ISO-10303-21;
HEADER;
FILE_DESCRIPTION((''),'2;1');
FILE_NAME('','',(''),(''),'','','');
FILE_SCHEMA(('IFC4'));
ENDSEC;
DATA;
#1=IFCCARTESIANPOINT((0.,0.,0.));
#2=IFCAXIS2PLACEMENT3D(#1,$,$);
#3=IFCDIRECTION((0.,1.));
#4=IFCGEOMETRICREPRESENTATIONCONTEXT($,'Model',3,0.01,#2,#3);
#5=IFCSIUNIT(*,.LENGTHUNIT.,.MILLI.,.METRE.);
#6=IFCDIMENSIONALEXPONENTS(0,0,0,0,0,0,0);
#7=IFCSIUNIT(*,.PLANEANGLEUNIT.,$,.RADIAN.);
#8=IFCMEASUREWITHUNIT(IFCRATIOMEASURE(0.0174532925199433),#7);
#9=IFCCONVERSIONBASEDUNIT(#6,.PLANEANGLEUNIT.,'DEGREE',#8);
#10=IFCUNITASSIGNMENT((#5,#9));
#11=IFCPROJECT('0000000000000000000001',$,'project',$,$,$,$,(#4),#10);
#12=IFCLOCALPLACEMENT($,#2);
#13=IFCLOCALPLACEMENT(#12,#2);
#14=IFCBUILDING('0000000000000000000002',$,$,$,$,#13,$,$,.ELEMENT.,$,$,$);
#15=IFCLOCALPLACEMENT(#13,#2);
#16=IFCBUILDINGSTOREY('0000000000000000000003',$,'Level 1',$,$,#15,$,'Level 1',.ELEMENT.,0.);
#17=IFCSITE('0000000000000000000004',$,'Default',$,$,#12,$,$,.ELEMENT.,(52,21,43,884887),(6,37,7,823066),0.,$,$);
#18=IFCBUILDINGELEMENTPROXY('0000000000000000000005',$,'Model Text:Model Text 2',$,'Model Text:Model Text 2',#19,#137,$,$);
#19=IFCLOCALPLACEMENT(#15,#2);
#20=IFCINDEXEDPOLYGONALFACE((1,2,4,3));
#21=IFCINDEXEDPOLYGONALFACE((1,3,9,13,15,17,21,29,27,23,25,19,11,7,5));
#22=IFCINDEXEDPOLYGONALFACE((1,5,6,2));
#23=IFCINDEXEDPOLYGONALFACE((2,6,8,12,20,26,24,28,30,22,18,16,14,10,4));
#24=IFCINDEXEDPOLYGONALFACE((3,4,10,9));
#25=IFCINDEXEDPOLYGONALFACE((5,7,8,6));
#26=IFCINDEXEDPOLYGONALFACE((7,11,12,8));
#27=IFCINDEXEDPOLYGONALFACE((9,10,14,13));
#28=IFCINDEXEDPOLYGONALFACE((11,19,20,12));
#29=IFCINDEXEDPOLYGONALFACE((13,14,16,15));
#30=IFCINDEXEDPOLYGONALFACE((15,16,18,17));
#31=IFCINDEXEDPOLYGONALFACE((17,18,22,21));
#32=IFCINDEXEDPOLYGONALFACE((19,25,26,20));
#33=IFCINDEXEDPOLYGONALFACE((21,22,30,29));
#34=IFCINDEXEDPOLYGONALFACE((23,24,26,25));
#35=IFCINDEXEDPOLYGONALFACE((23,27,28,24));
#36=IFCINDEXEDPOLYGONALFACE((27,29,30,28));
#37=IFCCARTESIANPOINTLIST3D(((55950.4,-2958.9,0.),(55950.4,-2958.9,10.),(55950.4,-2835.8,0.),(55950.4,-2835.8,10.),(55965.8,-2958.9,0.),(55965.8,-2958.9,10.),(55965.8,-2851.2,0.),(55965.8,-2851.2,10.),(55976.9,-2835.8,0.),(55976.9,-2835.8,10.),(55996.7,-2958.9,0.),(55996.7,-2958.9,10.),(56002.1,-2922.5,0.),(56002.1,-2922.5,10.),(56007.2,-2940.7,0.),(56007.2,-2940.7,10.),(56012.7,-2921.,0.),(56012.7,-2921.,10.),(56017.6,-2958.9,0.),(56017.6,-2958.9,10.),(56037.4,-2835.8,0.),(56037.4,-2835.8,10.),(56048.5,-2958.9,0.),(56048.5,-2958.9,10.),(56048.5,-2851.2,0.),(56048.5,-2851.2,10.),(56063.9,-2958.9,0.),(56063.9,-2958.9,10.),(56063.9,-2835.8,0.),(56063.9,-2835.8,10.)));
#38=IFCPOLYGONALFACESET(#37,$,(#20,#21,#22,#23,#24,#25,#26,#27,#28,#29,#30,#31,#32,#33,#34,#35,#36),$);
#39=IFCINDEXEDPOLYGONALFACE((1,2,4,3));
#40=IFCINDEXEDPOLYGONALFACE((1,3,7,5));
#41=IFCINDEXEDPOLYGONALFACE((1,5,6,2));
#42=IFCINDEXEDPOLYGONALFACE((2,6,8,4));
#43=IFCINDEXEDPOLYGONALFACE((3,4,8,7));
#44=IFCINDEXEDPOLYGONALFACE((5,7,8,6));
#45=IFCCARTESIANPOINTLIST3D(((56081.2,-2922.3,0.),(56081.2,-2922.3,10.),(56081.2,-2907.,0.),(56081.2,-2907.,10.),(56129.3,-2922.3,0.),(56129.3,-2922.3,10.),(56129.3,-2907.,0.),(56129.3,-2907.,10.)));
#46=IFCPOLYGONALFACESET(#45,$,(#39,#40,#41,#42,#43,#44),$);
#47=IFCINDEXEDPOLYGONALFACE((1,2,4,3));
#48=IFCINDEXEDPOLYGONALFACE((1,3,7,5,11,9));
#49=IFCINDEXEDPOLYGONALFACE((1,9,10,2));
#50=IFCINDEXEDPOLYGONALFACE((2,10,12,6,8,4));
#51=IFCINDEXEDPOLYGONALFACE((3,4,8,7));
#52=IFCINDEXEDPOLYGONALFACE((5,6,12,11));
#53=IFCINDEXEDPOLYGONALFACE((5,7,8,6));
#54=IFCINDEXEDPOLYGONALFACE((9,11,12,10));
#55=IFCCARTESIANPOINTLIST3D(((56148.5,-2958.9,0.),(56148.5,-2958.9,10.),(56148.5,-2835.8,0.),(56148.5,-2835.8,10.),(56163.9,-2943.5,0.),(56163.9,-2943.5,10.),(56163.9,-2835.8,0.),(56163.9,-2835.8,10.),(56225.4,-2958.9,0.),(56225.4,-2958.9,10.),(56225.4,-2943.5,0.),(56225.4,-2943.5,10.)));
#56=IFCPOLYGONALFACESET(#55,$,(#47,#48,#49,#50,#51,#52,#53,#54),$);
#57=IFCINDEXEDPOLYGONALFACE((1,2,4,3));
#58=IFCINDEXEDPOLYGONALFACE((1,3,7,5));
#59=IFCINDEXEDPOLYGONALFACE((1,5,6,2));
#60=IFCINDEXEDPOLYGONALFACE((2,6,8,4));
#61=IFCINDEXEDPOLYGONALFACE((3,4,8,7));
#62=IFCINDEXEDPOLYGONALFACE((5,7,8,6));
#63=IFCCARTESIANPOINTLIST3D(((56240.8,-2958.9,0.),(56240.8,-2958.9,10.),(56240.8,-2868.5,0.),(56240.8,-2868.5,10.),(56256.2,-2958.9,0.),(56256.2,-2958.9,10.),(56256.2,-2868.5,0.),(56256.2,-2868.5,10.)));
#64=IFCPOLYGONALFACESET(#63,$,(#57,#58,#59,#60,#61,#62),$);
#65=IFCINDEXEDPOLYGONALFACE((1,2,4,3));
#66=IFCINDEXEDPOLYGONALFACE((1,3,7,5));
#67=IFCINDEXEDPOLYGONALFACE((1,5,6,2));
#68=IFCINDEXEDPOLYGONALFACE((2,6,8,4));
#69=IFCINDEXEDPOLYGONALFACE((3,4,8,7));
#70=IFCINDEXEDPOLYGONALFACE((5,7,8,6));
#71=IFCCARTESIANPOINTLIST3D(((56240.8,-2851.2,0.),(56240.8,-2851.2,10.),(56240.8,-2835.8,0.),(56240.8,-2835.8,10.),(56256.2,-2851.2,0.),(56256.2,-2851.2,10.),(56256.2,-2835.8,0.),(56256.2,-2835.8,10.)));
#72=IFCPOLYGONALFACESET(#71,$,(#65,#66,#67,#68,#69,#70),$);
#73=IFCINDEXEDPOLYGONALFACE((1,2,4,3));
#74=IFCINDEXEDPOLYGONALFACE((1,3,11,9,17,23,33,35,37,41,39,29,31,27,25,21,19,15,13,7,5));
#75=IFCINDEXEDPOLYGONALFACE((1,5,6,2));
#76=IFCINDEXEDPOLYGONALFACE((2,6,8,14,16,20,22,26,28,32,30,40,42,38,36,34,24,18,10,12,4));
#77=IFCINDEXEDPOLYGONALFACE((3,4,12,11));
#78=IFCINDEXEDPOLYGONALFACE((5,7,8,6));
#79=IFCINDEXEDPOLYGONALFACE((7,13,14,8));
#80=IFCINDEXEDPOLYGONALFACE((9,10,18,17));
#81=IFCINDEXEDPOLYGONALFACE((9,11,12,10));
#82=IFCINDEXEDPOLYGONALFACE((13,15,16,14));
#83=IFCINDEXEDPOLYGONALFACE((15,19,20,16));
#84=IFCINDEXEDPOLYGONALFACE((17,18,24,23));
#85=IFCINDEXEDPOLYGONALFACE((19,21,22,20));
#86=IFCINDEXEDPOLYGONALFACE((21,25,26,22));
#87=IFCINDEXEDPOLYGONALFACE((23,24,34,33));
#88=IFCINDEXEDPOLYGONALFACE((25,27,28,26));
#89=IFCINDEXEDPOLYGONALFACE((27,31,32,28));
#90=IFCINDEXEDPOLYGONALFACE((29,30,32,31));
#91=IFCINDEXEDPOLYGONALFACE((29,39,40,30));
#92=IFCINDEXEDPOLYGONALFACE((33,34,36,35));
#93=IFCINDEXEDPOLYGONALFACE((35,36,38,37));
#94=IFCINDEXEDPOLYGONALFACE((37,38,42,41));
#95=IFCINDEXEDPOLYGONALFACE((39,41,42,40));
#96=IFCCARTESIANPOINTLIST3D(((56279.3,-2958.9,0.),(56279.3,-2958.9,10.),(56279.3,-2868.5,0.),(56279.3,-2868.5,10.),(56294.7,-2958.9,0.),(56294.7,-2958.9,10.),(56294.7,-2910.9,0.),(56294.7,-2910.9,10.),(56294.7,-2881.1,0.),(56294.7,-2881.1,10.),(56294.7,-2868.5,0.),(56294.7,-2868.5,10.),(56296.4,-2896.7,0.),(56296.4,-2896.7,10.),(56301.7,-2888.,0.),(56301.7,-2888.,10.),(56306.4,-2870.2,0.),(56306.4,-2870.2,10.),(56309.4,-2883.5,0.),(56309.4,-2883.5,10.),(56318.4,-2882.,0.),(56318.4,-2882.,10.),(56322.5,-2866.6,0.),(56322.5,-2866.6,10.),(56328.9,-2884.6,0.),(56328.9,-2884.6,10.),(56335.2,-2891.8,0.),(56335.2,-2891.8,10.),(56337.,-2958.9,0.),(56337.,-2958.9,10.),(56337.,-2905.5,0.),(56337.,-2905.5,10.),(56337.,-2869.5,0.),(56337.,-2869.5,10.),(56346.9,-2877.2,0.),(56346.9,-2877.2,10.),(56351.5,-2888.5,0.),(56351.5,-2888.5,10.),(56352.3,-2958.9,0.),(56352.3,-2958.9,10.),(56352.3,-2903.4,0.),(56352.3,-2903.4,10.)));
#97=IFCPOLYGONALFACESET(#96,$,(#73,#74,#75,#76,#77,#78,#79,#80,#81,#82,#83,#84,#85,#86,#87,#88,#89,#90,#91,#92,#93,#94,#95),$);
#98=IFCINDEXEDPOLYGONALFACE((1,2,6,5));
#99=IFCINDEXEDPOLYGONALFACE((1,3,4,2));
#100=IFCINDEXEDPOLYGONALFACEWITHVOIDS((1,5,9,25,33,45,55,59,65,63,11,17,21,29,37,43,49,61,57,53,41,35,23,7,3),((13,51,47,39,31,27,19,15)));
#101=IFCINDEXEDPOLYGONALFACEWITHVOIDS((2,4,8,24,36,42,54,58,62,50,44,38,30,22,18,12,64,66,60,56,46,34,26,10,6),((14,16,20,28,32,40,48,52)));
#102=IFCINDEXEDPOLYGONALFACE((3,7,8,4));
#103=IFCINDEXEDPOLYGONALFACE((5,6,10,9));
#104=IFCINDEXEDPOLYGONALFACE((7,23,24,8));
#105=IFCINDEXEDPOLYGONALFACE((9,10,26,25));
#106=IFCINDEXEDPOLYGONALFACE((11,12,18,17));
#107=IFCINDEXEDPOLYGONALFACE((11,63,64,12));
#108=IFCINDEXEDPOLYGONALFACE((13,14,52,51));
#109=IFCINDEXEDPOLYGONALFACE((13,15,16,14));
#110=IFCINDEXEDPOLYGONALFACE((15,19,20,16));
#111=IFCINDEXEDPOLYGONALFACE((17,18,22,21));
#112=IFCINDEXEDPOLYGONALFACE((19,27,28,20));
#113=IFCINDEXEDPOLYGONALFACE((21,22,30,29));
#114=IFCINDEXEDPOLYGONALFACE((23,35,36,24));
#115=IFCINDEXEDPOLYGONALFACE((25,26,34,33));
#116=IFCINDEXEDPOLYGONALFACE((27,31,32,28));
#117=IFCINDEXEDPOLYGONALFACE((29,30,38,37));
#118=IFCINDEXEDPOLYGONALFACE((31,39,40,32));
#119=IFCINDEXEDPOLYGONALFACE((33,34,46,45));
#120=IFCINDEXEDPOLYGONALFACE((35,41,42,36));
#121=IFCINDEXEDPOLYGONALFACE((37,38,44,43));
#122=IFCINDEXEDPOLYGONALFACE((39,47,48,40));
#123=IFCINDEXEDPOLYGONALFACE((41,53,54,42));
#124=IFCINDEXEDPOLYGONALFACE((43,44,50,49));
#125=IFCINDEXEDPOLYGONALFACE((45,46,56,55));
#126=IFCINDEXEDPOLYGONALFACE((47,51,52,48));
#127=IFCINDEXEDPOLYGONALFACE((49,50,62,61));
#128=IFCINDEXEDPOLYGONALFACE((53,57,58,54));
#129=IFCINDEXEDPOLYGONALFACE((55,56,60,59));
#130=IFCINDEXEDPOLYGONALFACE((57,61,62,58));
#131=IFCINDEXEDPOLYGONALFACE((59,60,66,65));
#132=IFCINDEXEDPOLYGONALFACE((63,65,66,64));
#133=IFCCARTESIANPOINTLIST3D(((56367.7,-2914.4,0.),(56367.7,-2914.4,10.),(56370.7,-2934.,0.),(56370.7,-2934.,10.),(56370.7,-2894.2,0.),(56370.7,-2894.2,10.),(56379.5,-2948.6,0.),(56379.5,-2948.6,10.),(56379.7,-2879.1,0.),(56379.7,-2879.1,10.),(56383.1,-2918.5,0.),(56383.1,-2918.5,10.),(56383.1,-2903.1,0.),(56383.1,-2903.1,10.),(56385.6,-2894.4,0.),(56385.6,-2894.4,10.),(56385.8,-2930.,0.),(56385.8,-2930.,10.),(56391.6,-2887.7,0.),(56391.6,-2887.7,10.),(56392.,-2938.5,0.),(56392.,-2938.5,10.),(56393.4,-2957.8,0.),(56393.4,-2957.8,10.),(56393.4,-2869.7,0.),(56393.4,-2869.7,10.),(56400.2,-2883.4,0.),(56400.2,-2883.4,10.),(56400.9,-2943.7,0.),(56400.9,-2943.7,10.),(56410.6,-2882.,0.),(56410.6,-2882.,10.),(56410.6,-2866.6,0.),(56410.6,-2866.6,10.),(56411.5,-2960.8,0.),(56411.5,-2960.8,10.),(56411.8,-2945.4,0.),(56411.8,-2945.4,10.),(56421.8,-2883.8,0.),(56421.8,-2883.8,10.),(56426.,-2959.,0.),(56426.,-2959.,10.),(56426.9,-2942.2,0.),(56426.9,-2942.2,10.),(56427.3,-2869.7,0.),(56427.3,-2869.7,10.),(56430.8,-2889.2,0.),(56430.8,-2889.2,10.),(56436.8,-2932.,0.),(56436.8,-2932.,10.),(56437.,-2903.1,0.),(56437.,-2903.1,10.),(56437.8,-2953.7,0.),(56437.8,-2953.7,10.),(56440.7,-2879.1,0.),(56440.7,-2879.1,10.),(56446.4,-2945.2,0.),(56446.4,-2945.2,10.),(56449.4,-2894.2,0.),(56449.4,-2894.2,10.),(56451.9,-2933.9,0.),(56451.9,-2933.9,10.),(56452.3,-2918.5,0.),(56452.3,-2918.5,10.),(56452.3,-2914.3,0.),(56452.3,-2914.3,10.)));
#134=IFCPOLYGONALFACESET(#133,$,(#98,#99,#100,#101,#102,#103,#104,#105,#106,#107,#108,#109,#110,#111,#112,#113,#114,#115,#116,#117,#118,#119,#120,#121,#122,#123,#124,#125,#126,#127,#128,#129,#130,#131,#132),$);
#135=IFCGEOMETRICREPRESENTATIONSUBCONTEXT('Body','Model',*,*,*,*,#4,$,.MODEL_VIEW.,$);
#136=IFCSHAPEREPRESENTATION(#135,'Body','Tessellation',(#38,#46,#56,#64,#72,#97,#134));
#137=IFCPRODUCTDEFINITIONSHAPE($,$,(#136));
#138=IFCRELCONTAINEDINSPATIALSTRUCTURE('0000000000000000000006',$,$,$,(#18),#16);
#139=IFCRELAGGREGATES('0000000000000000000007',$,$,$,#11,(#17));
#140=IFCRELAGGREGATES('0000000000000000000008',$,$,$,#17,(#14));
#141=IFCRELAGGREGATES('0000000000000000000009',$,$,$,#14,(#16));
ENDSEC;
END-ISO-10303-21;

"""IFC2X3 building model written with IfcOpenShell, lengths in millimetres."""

from ifc_helpers import new_model, entity, si_unit, converted_unit, direction, frame, frame_2d, origin, origin_2d_with_axis, place, context, subcontext, project, spatial, polyline, rectangle, outline, extrude, element, save


model = new_model("IFC2X3")

# Units and contexts
model_context = context("Model", 3, precision=0.01, world=origin(), true_north=direction((0.0, 1.0)))
body_context = subcontext(model_context, "Body", "Model", "MODEL_VIEW")
ifc_project = project(units=[si_unit("LENGTHUNIT", "METRE", prefix="MILLI"), converted_unit("PLANEANGLEUNIT", "DEGREE", entity("IfcRatioMeasure", 0.0174532925199433), si_unit("PLANEANGLEUNIT", "RADIAN"), dimensions=[0, 0, 0, 0, 0, 0, 0])], contexts=[model_context])

# Site, building, storey
site_placement = place(None, origin())
site = spatial("IfcSite", under=ifc_project, at=site_placement, Name="Default", CompositionType="ELEMENT", RefLatitude=(52, 21, 43, 884887), RefLongitude=(6, 37, 7, 823066), RefElevation=0.0)
building_placement = place(site_placement, origin())
building = spatial("IfcBuilding", under=site, at=building_placement, CompositionType="ELEMENT")
storey_placement = place(building_placement, origin())
storey = spatial("IfcBuildingStorey", under=building, at=storey_placement, Name="Level 1", LongName="Level 1", CompositionType="ELEMENT", Elevation=0.0)

# Building element proxy
proxy_1_placement = place(storey_placement, origin())
element("IfcBuildingElementProxy", 1, at=proxy_1_placement, inside=storey, Name="Model Text:Model Text 2", ObjectType="Model Text:Model Text 2", context=body_context, shape_type="SweptSolid", body=[
    extrude(outline(polyline([(-56.8, -53.3), (-41.4, -53.3), (-41.4, 54.4), (-10.5, -53.3), (10.4, -53.3), (41.3, 54.4), (41.3, -53.3), (56.7, -53.3), (56.7, 69.7), (30.2, 69.7), (5.5, -15.5), (0.0, -35.1), (-5.1, -17.0), (-30.3, 69.7), (-56.8, 69.7), (-56.8, -53.3)])), frame((56007.2, -2905.5, 0.0)), (0.0, 0.0, 1.0), 10.0),
    extrude(rectangle(XDim=48.1, YDim=15.4, at=origin_2d_with_axis()), frame((56105.2, -2914.6, 0.0)), (0.0, 0.0, 1.0), 10.0),
    extrude(outline(polyline([(-30.8, -46.2), (46.2, -46.2), (46.2, -30.8), (-15.4, -30.8), (-15.4, 76.9), (-30.8, 76.9), (-30.8, -46.2)])), frame((56179.3, -2912.7, 0.0)), (0.0, 0.0, 1.0), 10.0),
    extrude(rectangle(XDim=15.4, YDim=90.4, at=frame_2d((0.0, 0.0), x_axis=(1.0, 0.0))), frame((56248.5, -2913.7, 0.0)), (0.0, 0.0, 1.0), 10.0),
    extrude(rectangle(XDim=15.4, YDim=15.4, at=frame_2d((0.0, 0.0), x_axis=(1.0, 0.0))), frame((56248.5, -2843.5, 0.0)), (0.0, 0.0, 1.0), 10.0),
    extrude(outline(polyline([(-38.4, -60.2), (-23.0, -60.2), (-23.0, -12.3), (-21.2, 1.9), (-16.0, 10.7), (-8.3, 15.2), (0.7, 16.7), (11.3, 14.0), (17.6, 6.8), (19.3, -6.8), (19.3, -60.2), (34.7, -60.2), (34.7, -4.7), (33.9, 10.2), (29.3, 21.5), (19.4, 29.2), (4.9, 32.1), (-11.2, 28.5), (-23.0, 17.6), (-23.0, 30.2), (-38.4, 30.2), (-38.4, -60.2)])), frame((56317.6, -2898.7, 0.0)), (0.0, 0.0, 1.0), 10.0),
    extrude(outline(polyline([(-9.9, -25.0), (-19.0, -37.1), (-7.1, -41.1), (5.1, -40.8), (17.0, -36.1), (28.4, -26.8), (38.8, -11.8), (41.9, 4.6), (37.5, 21.1), (25.5, 36.8), (8.9, 48.7), (-8.2, 52.8), (-24.5, 49.5), (-38.7, 39.3), (-48.1, 25.1), (-50.6, 9.0), (-45.9, -7.8), (-33.4, -23.9), (-30.4, -26.7), (17.7, 23.0), (24.1, 13.0), (25.9, 2.7), (23.5, -7.3), (17.1, -16.4), (4.3, -25.0), (-9.9, -25.0)]), holes=[polyline([(6.7, 33.7), (-30.8, -5.0), (-36.5, 9.1), (-34.2, 19.3), (-27.6, 28.7), (-19.4, 35.1), (-10.3, 38.3), (-1.3, 37.9), (6.7, 33.7)])]), frame((56411.9, -2921.7, 0.0), z_axis=(0.0, 0.0, -1.0), x_axis=(-0.695421, -0.718602, 0.0)), (0.0, 0.0, -1.0), 10.0),
])

save(model, "model.ifc")
